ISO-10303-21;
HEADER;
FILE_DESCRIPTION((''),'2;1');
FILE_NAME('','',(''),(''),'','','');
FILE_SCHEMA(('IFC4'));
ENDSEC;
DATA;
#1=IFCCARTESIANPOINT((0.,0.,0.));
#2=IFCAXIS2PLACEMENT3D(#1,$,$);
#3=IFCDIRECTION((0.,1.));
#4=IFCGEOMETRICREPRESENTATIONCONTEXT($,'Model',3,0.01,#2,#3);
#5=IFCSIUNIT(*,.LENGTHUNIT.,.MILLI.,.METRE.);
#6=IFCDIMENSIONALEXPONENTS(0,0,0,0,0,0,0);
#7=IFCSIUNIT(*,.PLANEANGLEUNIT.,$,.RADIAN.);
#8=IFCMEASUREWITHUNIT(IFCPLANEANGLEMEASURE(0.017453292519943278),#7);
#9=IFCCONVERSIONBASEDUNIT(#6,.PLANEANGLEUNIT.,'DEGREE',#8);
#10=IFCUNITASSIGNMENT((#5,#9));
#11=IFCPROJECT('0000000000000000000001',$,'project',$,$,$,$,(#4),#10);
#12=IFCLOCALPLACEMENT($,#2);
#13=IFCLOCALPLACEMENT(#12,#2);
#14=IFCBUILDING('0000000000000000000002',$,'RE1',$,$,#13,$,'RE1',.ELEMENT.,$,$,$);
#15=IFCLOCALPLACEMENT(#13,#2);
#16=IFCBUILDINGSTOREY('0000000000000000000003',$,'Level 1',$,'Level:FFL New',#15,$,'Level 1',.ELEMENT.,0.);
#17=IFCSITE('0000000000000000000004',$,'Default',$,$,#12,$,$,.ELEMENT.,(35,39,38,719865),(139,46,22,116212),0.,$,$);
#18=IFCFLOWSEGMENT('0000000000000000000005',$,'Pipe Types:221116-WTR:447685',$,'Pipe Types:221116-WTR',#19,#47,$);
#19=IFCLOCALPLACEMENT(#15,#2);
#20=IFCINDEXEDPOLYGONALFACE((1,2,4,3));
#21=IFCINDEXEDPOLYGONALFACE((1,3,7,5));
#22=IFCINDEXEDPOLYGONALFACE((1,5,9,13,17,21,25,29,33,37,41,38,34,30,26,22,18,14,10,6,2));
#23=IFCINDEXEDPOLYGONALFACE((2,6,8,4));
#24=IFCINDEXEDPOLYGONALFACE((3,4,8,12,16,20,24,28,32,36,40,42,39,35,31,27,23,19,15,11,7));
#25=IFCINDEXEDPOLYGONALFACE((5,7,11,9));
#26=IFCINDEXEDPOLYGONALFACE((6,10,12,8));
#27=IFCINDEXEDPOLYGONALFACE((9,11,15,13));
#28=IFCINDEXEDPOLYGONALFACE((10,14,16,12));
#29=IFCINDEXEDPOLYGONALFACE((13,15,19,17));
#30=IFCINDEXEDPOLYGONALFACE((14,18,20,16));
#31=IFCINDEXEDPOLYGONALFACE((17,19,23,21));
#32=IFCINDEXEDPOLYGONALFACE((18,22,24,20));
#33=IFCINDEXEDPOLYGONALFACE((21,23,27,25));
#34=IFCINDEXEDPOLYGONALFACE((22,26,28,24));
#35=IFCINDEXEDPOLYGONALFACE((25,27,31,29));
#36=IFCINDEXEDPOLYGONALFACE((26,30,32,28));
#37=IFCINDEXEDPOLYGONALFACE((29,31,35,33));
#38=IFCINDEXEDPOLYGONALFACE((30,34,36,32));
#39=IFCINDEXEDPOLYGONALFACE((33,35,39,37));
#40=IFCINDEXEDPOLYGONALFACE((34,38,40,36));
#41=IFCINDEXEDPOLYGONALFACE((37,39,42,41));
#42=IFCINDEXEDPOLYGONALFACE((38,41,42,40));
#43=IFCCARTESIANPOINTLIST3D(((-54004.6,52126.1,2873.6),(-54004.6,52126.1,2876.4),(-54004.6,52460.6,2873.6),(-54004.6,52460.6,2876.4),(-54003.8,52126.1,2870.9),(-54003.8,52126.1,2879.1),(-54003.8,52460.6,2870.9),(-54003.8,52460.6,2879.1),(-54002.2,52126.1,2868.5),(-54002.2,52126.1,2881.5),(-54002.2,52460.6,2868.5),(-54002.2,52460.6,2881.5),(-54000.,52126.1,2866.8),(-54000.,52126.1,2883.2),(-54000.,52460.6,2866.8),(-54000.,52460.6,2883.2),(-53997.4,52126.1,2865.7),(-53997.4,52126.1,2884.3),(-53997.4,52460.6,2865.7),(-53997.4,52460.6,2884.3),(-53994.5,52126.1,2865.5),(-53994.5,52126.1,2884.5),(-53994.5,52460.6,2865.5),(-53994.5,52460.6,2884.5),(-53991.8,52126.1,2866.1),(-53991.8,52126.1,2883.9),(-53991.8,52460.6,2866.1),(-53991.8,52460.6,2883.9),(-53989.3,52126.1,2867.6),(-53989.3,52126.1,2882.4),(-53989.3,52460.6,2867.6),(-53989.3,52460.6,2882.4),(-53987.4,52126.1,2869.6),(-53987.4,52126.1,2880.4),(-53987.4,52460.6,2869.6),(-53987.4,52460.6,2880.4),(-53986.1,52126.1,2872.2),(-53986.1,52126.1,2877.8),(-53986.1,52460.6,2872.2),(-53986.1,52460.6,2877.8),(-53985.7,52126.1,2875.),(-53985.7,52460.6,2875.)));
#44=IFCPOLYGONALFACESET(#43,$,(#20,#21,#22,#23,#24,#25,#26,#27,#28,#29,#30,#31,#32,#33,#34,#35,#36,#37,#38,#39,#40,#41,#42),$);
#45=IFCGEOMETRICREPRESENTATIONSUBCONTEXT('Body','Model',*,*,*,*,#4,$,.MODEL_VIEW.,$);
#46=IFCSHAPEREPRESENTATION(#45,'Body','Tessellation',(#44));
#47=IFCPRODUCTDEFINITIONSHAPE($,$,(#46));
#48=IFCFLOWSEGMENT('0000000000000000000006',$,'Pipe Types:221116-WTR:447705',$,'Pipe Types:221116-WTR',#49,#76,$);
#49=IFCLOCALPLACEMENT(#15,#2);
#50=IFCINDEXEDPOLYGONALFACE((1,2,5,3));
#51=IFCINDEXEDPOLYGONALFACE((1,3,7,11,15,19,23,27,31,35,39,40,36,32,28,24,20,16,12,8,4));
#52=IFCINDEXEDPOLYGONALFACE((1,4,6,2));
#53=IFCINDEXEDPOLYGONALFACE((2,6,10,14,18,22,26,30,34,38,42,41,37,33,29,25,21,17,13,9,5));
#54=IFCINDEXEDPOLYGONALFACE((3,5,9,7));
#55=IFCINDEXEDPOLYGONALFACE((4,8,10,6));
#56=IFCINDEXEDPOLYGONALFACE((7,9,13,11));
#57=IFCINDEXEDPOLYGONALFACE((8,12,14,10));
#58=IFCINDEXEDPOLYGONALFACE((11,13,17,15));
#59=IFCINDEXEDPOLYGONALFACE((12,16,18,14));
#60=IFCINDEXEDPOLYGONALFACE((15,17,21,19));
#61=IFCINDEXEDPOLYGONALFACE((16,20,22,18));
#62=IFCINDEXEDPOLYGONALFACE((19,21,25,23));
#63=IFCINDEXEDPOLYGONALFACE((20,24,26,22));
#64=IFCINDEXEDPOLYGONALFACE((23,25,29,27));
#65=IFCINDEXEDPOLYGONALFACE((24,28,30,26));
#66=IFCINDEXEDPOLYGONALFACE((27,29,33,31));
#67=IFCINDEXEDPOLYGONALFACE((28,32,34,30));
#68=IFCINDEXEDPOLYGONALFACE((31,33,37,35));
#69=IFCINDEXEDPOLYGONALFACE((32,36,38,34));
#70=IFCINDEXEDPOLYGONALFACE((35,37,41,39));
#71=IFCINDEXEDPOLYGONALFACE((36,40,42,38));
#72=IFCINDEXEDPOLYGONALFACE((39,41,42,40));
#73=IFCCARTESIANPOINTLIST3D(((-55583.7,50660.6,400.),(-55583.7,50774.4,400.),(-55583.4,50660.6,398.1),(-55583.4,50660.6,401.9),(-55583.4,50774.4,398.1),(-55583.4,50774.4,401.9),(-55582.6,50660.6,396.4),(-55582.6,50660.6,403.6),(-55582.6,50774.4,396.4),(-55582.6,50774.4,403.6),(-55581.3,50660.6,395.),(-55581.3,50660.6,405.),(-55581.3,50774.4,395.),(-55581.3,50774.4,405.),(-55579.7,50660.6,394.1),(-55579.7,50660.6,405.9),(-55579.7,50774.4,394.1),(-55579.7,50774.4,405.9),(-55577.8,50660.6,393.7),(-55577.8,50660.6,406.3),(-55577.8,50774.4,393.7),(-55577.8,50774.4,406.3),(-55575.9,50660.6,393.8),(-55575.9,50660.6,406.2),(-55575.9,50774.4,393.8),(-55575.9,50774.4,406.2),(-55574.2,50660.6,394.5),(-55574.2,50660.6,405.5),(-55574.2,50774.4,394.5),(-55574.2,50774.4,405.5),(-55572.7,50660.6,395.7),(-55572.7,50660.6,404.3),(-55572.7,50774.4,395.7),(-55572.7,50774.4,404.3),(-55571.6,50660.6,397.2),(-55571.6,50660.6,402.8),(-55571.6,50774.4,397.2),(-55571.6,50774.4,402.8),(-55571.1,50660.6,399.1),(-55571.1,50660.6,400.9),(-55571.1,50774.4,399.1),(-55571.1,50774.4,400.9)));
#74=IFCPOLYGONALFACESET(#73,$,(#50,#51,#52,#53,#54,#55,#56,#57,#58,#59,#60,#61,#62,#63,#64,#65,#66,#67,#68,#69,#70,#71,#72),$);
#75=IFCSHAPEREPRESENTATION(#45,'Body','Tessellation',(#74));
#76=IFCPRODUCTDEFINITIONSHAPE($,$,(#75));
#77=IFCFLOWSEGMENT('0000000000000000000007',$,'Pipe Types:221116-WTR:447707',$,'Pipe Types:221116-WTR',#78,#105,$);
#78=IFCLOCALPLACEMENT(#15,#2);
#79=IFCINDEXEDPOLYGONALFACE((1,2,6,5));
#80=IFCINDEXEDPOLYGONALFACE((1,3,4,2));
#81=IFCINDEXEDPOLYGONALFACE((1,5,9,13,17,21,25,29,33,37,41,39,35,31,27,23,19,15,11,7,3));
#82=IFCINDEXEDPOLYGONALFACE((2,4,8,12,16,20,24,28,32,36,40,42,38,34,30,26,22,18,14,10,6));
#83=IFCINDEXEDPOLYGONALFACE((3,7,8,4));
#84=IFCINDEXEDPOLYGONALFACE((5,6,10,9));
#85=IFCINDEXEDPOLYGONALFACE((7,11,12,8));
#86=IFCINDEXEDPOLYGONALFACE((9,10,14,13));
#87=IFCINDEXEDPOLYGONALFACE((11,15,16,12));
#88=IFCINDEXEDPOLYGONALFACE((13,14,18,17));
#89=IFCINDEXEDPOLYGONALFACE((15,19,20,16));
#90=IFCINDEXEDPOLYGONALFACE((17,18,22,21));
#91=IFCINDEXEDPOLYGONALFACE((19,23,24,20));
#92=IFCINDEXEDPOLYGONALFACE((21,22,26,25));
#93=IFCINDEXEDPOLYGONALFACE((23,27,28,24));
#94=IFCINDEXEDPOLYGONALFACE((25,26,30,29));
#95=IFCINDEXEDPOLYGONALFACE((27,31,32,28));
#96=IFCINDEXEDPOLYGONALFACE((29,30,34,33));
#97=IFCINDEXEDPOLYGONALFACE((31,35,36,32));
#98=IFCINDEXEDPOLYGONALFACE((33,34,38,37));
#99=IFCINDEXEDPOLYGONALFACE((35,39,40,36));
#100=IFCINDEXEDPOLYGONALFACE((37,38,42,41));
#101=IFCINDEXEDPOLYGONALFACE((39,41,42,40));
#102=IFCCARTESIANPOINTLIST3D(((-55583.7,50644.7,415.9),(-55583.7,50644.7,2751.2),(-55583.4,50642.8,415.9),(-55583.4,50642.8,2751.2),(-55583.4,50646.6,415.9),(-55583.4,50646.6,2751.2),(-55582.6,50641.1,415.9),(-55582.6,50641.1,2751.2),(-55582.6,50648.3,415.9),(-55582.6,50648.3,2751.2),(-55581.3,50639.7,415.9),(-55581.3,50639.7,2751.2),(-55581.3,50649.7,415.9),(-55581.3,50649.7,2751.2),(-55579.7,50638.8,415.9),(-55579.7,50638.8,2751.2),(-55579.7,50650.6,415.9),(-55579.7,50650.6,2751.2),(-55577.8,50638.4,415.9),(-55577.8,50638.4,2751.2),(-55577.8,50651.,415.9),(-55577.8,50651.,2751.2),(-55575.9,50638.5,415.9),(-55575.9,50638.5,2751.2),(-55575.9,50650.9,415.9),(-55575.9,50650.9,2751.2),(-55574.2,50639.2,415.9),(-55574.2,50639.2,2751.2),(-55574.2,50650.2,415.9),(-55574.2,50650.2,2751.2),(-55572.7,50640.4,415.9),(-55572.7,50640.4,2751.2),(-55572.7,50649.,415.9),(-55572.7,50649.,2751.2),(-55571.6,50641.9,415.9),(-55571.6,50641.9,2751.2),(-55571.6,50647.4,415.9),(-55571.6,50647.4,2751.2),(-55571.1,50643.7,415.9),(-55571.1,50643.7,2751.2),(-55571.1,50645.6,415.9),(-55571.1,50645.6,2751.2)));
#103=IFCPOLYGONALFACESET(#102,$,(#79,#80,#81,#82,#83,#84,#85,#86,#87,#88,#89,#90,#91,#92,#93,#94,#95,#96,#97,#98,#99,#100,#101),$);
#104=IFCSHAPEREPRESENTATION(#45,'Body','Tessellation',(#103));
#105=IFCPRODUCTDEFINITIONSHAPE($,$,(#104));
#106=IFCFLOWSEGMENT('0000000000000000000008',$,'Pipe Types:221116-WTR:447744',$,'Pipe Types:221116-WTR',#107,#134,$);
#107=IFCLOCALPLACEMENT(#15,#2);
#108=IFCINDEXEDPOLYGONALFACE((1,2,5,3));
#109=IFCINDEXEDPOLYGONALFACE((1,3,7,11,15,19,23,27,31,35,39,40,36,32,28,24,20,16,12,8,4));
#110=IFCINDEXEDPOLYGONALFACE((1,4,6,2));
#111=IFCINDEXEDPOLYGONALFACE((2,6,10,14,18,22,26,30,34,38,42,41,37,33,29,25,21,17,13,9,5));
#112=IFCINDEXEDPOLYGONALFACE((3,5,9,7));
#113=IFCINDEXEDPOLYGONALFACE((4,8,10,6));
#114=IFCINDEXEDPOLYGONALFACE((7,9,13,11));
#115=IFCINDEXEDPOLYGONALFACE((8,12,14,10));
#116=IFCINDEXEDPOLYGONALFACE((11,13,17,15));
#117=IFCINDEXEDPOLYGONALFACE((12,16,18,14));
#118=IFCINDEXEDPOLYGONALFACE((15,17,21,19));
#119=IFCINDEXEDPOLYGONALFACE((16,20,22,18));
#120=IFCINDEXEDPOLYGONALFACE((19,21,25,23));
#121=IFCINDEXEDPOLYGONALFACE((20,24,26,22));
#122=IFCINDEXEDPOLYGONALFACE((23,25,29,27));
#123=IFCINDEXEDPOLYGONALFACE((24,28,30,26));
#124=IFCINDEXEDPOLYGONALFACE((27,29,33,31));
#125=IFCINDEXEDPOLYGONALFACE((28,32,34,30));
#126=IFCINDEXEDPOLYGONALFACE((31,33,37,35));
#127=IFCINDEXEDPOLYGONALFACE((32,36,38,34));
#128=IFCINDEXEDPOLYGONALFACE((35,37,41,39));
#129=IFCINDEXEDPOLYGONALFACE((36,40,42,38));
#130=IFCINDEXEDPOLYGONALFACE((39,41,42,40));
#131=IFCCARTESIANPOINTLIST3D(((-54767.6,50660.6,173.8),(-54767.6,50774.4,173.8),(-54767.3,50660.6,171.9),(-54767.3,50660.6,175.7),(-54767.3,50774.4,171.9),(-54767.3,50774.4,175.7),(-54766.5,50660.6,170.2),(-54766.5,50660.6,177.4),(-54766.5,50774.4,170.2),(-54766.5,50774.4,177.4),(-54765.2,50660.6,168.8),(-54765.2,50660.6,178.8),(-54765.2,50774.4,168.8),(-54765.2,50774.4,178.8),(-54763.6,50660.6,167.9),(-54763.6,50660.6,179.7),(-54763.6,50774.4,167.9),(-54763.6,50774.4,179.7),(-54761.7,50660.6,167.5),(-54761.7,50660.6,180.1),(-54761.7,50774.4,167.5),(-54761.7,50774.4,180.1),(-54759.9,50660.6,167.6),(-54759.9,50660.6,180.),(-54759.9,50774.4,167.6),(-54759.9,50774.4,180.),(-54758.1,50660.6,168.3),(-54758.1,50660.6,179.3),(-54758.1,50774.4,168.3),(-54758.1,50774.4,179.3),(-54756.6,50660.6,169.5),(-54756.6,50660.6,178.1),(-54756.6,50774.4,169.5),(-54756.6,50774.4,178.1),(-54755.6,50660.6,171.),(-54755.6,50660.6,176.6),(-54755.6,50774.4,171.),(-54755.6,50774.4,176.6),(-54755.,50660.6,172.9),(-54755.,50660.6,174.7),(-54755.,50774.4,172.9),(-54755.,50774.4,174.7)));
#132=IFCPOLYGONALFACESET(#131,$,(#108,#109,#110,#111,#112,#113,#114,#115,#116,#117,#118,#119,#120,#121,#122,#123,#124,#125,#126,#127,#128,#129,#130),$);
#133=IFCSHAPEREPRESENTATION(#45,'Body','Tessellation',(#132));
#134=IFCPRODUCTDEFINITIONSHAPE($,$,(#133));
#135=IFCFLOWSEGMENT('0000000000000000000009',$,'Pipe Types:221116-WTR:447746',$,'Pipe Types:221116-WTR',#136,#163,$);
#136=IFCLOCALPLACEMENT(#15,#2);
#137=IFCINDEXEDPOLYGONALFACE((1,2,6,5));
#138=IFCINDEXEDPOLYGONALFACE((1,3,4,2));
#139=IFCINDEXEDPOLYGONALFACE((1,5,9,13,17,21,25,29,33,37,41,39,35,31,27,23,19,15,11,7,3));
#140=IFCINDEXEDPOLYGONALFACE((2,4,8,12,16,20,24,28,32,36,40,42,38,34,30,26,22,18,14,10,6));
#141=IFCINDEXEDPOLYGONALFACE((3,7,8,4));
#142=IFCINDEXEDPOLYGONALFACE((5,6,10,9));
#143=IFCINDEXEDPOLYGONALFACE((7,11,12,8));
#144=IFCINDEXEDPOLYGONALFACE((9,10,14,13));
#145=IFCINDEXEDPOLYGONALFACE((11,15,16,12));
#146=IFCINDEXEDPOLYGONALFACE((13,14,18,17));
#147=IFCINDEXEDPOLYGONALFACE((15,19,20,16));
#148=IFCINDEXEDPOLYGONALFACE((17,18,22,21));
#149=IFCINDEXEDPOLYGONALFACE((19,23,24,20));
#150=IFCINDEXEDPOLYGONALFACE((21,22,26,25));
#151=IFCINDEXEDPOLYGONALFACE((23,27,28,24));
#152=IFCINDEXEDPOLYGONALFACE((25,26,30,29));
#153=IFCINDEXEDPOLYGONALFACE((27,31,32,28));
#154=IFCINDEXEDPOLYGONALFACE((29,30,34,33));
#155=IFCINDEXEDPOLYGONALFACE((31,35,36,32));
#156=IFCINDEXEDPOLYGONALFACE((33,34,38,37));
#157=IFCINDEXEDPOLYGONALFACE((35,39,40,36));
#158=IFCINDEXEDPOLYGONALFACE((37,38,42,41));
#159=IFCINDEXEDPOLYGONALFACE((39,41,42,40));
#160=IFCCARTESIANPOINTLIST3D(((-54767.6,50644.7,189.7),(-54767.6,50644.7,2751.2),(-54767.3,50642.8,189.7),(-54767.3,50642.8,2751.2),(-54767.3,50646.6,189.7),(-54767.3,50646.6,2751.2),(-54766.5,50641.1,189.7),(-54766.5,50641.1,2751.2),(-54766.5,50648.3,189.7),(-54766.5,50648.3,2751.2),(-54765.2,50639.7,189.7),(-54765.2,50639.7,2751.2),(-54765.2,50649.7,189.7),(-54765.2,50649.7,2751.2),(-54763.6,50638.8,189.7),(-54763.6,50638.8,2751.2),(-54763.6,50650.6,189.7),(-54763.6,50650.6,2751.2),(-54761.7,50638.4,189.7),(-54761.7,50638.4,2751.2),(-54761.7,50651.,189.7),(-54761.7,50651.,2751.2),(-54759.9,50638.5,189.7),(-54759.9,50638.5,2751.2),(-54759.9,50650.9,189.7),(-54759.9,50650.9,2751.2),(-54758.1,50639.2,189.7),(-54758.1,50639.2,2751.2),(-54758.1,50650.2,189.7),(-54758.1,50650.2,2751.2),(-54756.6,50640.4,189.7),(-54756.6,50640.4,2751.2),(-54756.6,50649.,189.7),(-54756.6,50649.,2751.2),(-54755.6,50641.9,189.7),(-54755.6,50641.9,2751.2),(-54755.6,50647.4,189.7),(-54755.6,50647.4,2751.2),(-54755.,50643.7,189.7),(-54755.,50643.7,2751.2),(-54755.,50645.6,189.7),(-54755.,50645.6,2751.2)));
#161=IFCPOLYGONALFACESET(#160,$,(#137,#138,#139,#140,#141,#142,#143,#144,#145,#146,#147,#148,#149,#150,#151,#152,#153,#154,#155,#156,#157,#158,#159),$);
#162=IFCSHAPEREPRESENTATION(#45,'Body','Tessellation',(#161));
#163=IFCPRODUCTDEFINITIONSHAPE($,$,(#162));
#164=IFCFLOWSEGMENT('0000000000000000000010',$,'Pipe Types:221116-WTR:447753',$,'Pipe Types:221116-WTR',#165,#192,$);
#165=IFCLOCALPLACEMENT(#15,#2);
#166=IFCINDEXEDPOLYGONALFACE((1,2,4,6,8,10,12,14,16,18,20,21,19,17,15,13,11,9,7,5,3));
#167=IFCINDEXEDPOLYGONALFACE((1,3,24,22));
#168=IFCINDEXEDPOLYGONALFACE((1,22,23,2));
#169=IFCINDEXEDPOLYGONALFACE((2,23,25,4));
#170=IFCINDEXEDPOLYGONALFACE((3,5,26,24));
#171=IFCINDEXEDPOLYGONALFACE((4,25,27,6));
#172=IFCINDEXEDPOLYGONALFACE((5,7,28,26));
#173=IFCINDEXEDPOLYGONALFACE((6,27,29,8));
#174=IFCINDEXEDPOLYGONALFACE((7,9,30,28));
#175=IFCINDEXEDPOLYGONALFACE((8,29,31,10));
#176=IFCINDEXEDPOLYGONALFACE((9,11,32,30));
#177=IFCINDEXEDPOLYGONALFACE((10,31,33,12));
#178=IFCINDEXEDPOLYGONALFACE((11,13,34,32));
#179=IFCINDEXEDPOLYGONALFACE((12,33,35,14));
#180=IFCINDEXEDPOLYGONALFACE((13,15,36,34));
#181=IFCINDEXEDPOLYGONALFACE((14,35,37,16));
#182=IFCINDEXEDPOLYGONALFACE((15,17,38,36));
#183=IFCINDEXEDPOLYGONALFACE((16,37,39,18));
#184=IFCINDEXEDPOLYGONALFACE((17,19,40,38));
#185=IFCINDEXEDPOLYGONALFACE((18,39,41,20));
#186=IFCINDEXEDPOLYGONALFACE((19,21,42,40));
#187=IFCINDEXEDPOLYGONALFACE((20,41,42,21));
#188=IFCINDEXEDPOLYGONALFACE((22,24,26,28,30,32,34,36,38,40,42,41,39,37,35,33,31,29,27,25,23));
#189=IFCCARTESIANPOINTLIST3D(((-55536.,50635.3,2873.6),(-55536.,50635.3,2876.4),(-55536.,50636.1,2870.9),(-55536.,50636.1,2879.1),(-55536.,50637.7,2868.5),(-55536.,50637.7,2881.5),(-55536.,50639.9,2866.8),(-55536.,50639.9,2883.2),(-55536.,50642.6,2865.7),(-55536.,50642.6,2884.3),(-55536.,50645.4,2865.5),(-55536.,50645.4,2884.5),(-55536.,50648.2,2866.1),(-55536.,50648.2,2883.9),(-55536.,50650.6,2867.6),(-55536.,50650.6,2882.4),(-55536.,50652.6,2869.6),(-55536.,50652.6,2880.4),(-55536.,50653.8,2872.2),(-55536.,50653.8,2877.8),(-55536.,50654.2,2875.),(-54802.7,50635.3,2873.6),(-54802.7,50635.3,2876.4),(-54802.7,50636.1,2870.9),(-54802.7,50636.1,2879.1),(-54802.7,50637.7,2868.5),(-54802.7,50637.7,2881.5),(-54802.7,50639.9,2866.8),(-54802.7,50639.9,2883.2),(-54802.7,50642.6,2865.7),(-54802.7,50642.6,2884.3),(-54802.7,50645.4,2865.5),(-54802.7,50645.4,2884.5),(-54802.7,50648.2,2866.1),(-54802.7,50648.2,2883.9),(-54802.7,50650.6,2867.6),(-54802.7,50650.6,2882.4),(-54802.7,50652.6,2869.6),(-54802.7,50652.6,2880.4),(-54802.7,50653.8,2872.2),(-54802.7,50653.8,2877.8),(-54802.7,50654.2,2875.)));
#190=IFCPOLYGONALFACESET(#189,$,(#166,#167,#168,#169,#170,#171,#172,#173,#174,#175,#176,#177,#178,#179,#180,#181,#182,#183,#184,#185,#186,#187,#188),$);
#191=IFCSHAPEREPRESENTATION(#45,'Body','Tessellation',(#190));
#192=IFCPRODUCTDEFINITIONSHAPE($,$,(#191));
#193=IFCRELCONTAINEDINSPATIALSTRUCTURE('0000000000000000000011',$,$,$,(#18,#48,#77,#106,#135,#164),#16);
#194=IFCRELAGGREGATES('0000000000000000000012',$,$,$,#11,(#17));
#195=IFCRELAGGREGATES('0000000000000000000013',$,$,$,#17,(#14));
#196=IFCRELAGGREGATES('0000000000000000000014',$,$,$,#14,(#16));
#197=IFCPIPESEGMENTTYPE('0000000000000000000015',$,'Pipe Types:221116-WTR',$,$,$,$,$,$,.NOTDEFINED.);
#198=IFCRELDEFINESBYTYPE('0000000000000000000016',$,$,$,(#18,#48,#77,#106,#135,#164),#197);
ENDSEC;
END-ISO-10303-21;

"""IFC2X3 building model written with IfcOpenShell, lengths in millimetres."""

from ifc_helpers import new_model, entity, si_unit, converted_unit, direction, frame, frame_2d, origin, origin_2d_with_axis, place, context, subcontext, project, spatial, circle, extrude, type_object, element, save


model = new_model("IFC2X3")

# Units and contexts
model_context = context("Model", 3, precision=0.01, world=origin(), true_north=direction((0.0, 1.0)))
body_context = subcontext(model_context, "Body", "Model", "MODEL_VIEW")
ifc_project = project(units=[si_unit("LENGTHUNIT", "METRE", prefix="MILLI"), converted_unit("PLANEANGLEUNIT", "DEGREE", entity("IfcPlaneAngleMeasure", 0.017453292519943278), si_unit("PLANEANGLEUNIT", "RADIAN"), dimensions=[0, 0, 0, 0, 0, 0, 0])], contexts=[model_context])

# Site, building, storey
site_placement = place(None, origin())
site = spatial("IfcSite", under=ifc_project, at=site_placement, Name="Default", CompositionType="ELEMENT", RefLatitude=(35, 39, 38, 719865), RefLongitude=(139, 46, 22, 116212), RefElevation=0.0)
building_placement = place(site_placement, origin())
building = spatial("IfcBuilding", under=site, at=building_placement, Name="RE1", LongName="RE1", CompositionType="ELEMENT")
storey_placement = place(building_placement, origin())
storey = spatial("IfcBuildingStorey", under=building, at=storey_placement, Name="Level 1", ObjectType="Level:FFL New", LongName="Level 1", CompositionType="ELEMENT", Elevation=0.0)

# Flow segments
pipe_segment_type_1 = type_object("IfcPipeSegmentType", Name="Pipe Types:221116-WTR", PredefinedType="NOTDEFINED")
flow_segment_1_placement = place(storey_placement, origin())
element("IfcFlowSegment", 1, at=flow_segment_1_placement, inside=storey, type_object=pipe_segment_type_1, Name="Pipe Types:221116-WTR:447685", ObjectType="Pipe Types:221116-WTR", context=body_context, shape_type="SweptSolid", body=[
    extrude(circle(Radius=9.5, at=origin_2d_with_axis()), frame((-53995.2, 52126.1, 2875.0), z_axis=(0.0, 1.0, 0.0), x_axis=(1.0, 0.0, 0.0)), (0.0, 0.0, 1.0), 334.6),
])
flow_segment_2_placement = place(storey_placement, origin())
element("IfcFlowSegment", 2, at=flow_segment_2_placement, inside=storey, type_object=pipe_segment_type_1, Name="Pipe Types:221116-WTR:447705", ObjectType="Pipe Types:221116-WTR", context=body_context, shape_type="SweptSolid", body=[
    extrude(circle(Radius=6.3, at=frame_2d((0.0, 0.0), x_axis=(1.0, 0.0))), frame((-55577.4, 50660.6, 400.0), z_axis=(0.0, 1.0, 0.0), x_axis=(-1.0, 0.0, 0.0)), (0.0, 0.0, 1.0), 113.9),
])
flow_segment_3_placement = place(storey_placement, origin())
element("IfcFlowSegment", 3, at=flow_segment_3_placement, inside=storey, type_object=pipe_segment_type_1, Name="Pipe Types:221116-WTR:447707", ObjectType="Pipe Types:221116-WTR", context=body_context, shape_type="SweptSolid", body=[
    extrude(circle(Radius=6.3, at=frame_2d((0.0, 0.0), x_axis=(1.0, 0.0))), frame((-55577.4, 50644.7, 415.9), z_axis=(0.0, 0.0, 1.0), x_axis=(-1.0, 0.0, 0.0)), (0.0, 0.0, 1.0), 2335.3),
])
flow_segment_4_placement = place(storey_placement, origin())
element("IfcFlowSegment", 4, at=flow_segment_4_placement, inside=storey, type_object=pipe_segment_type_1, Name="Pipe Types:221116-WTR:447744", ObjectType="Pipe Types:221116-WTR", context=body_context, shape_type="SweptSolid", body=[
    extrude(circle(Radius=6.3, at=origin_2d_with_axis()), frame((-54761.3, 50660.6, 173.8), z_axis=(0.0, 1.0, 0.0), x_axis=(-1.0, 0.0, 0.0)), (0.0, 0.0, 1.0), 113.9),
])
flow_segment_5_placement = place(storey_placement, origin())
element("IfcFlowSegment", 5, at=flow_segment_5_placement, inside=storey, type_object=pipe_segment_type_1, Name="Pipe Types:221116-WTR:447746", ObjectType="Pipe Types:221116-WTR", context=body_context, shape_type="SweptSolid", body=[
    extrude(circle(Radius=6.3, at=origin_2d_with_axis()), frame((-54761.3, 50644.7, 189.7), z_axis=(0.0, 0.0, 1.0), x_axis=(-1.0, 0.0, 0.0)), (0.0, 0.0, 1.0), 2561.5),
])
flow_segment_6_placement = place(storey_placement, origin())
element("IfcFlowSegment", 6, at=flow_segment_6_placement, inside=storey, type_object=pipe_segment_type_1, Name="Pipe Types:221116-WTR:447753", ObjectType="Pipe Types:221116-WTR", context=body_context, shape_type="SweptSolid", body=[
    extrude(circle(Radius=9.5, at=origin_2d_with_axis()), frame((-55536.0, 50644.7, 2875.0), z_axis=(1.0, 0.0, 0.0), x_axis=(0.0, 1.0, 0.0)), (0.0, 0.0, 1.0), 733.3),
])

save(model, "model.ifc")
